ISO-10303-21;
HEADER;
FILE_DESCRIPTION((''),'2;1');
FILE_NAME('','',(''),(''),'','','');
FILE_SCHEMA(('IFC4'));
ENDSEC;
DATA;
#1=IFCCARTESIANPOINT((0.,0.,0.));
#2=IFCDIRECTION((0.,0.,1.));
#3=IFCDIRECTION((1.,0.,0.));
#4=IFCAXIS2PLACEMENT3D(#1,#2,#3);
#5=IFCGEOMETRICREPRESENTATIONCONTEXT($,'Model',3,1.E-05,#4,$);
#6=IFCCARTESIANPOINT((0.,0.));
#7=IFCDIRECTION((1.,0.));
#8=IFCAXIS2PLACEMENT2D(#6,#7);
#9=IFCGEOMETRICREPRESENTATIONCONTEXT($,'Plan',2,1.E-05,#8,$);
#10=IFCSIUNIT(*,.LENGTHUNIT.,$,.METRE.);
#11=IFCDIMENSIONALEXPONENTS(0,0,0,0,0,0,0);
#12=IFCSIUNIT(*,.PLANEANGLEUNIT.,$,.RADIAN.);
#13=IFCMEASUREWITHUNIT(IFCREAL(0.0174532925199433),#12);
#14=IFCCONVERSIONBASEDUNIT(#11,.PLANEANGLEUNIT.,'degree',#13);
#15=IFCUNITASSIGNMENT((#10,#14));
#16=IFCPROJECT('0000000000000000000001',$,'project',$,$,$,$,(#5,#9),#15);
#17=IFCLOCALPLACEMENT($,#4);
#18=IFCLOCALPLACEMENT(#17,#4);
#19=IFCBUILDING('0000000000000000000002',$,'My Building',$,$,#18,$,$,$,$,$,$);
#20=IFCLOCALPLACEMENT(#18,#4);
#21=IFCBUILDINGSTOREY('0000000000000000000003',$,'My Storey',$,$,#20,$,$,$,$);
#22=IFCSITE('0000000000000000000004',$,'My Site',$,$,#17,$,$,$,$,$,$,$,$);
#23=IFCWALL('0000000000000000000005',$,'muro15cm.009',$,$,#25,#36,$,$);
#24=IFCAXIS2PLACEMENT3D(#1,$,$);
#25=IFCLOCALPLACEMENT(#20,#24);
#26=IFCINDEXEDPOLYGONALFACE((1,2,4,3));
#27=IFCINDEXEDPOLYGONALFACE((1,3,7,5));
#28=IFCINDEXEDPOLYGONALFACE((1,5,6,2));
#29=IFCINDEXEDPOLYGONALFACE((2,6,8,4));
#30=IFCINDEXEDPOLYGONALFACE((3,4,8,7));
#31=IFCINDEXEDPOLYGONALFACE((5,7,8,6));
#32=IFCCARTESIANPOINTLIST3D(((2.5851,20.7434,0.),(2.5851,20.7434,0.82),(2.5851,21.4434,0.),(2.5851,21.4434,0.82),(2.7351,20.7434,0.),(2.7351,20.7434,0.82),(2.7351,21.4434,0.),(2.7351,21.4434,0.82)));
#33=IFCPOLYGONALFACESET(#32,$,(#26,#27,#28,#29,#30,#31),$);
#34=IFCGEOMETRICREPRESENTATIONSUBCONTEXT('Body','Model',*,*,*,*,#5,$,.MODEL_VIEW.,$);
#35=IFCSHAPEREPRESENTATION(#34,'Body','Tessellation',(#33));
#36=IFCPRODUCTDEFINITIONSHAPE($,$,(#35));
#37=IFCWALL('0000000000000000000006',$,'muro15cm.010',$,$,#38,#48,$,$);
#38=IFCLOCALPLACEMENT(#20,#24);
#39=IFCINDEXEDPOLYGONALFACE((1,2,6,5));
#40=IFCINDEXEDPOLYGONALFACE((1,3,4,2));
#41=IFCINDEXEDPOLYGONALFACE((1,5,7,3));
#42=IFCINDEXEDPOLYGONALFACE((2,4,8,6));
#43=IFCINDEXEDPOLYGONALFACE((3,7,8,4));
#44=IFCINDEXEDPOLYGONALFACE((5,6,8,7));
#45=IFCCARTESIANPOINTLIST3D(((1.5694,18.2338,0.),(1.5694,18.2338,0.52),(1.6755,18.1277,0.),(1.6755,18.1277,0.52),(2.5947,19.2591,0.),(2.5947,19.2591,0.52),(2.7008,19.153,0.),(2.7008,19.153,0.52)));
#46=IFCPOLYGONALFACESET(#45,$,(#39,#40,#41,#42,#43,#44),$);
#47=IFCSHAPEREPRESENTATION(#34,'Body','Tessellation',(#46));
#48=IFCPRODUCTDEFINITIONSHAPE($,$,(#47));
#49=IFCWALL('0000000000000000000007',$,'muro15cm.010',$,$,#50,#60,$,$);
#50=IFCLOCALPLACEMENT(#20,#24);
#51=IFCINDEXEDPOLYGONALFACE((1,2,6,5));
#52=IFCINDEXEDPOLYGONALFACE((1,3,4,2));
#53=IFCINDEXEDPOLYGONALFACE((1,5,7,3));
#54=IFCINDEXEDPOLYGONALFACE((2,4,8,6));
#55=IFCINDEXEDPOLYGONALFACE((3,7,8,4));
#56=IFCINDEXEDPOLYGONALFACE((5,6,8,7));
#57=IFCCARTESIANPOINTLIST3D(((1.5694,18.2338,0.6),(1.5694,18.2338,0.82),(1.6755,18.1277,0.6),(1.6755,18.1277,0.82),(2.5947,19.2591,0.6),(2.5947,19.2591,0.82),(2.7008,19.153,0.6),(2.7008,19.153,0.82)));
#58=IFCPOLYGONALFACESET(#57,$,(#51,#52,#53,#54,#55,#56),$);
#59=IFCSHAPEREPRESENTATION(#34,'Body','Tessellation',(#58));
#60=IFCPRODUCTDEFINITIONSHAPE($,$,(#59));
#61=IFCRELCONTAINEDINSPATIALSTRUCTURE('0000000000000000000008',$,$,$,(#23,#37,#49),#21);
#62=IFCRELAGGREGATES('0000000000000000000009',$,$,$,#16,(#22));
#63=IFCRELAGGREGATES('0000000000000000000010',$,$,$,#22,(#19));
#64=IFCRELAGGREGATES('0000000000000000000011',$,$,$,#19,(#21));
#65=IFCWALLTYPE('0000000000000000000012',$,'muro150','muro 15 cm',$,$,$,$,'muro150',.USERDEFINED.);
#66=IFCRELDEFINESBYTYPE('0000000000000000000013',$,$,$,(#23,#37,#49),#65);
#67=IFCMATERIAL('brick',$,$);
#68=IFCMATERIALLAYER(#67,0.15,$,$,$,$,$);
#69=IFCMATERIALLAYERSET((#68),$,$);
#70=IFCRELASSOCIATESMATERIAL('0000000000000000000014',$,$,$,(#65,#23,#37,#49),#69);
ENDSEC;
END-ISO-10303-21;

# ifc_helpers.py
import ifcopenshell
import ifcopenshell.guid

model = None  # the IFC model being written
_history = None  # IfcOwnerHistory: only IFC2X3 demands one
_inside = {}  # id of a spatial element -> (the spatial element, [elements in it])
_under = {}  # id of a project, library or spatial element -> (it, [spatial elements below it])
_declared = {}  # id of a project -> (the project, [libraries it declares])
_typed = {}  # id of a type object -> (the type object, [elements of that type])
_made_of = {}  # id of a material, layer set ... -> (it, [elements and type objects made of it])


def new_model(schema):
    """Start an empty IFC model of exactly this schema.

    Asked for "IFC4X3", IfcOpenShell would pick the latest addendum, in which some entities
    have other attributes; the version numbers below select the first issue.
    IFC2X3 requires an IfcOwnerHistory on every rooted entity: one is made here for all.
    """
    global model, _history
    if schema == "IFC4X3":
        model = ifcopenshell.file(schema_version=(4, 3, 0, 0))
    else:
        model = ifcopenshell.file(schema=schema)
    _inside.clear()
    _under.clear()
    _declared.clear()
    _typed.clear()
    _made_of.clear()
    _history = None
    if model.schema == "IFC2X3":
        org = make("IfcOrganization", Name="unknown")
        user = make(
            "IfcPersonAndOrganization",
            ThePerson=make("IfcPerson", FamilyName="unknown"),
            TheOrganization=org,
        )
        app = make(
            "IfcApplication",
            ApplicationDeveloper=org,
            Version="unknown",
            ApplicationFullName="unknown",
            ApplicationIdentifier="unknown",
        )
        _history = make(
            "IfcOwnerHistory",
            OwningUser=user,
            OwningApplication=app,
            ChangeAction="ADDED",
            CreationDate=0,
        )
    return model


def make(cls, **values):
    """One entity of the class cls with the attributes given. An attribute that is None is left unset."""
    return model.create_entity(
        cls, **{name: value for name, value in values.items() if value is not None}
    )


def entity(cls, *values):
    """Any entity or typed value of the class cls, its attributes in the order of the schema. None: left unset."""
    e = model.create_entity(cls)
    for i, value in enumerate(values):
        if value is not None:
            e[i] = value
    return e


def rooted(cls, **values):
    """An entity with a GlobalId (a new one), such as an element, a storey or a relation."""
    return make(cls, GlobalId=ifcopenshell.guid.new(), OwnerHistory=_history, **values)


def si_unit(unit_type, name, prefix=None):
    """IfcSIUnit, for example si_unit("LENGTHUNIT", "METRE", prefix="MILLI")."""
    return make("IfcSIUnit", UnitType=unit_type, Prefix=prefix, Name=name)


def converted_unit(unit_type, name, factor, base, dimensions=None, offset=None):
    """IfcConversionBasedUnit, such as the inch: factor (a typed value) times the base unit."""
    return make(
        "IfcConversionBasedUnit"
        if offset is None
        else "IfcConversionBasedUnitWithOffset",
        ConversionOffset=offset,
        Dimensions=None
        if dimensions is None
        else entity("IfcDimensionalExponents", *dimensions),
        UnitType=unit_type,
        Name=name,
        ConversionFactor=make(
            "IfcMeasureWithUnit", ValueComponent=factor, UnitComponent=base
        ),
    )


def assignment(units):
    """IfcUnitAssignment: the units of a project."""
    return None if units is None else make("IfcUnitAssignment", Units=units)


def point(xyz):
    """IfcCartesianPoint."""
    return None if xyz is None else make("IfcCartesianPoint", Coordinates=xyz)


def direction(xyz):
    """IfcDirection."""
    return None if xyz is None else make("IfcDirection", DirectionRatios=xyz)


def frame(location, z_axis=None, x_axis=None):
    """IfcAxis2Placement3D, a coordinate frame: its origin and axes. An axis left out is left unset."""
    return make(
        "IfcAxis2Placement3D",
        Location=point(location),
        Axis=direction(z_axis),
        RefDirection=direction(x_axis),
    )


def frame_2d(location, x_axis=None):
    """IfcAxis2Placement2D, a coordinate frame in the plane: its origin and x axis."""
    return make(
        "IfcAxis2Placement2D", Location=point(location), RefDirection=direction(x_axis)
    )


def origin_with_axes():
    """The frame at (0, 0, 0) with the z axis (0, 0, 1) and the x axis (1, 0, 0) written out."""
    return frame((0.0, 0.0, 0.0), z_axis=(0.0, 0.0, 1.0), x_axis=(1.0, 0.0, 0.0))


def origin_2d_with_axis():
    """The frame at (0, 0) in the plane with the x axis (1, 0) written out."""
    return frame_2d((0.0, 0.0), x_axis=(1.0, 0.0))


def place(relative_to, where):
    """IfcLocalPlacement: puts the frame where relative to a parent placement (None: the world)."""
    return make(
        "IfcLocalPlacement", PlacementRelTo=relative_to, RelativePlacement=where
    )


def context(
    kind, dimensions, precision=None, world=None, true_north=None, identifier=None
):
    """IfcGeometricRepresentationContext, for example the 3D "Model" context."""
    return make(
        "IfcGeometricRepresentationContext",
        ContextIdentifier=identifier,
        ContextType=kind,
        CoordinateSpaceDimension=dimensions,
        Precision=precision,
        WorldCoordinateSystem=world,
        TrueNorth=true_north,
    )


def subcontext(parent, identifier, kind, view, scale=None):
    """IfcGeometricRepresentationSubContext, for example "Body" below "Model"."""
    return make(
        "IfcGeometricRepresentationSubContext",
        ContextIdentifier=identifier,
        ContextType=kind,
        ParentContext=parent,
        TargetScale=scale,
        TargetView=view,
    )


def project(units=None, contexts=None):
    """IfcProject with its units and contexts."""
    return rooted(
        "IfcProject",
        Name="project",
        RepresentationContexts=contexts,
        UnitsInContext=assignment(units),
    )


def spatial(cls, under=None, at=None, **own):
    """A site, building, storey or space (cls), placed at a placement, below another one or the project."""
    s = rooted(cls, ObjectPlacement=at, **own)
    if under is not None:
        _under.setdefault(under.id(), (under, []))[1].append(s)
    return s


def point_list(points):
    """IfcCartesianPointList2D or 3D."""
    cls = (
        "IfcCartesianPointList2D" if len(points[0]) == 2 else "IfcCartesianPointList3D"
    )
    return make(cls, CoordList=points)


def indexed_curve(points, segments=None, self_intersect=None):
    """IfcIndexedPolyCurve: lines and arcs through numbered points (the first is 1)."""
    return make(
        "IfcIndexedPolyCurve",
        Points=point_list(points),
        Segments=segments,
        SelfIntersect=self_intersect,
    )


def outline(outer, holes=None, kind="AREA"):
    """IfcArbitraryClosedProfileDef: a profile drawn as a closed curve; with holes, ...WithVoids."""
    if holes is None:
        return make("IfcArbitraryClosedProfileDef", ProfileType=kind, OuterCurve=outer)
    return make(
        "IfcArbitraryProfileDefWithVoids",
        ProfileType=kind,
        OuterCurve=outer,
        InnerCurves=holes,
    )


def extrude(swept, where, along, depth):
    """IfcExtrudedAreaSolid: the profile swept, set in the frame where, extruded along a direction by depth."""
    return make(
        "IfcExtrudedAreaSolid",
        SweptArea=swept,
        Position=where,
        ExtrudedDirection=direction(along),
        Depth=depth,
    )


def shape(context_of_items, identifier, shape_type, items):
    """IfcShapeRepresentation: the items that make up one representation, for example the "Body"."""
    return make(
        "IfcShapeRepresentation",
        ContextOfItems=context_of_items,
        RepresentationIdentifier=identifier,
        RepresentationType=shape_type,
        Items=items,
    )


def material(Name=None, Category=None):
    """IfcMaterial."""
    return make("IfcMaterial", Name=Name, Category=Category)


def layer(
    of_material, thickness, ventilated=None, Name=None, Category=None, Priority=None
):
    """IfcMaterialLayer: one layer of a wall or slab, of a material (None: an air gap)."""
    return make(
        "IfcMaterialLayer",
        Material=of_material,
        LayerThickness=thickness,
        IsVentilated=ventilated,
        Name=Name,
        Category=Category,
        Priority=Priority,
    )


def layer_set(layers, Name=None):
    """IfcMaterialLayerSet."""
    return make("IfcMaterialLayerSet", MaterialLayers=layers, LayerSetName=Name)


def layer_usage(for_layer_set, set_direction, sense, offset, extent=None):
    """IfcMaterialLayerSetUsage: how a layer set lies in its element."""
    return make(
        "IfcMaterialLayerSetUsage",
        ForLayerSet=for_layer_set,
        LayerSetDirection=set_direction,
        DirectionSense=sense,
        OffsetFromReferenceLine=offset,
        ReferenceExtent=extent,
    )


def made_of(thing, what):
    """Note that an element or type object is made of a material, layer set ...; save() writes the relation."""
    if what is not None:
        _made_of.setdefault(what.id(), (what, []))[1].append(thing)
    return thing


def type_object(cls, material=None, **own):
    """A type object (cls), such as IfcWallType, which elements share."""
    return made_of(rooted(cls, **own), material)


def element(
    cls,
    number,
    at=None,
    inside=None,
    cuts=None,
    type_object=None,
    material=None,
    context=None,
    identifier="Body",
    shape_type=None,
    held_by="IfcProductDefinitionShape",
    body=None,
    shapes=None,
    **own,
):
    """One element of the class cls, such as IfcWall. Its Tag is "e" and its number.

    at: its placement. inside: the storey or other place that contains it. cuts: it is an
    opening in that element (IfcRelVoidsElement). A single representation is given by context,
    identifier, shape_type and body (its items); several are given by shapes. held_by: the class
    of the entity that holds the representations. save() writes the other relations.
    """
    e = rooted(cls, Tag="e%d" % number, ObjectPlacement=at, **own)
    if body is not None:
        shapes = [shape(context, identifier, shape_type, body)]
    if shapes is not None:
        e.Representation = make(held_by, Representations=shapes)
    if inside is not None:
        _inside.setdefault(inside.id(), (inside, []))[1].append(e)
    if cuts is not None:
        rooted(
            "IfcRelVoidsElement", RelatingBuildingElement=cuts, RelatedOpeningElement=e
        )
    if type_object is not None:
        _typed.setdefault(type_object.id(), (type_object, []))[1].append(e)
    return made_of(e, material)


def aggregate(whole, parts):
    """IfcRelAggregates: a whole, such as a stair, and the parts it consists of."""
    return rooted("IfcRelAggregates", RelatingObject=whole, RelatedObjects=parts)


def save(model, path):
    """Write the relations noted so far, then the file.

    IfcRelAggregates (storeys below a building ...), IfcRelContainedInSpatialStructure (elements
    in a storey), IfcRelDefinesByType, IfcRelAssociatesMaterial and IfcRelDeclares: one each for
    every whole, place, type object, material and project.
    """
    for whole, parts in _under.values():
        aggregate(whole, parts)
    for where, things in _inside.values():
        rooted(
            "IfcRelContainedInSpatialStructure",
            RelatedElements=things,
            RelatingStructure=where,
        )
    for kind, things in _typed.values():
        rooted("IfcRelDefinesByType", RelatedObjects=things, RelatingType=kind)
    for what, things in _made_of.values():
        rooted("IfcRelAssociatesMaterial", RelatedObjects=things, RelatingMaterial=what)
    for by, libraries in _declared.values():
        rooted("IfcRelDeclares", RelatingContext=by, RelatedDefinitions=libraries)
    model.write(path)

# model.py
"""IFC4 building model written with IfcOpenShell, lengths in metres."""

from ifc_helpers import new_model, entity, si_unit, converted_unit, frame, origin_with_axes, origin_2d_with_axis, place, context, subcontext, project, spatial, indexed_curve, outline, extrude, material, layer, layer_set, layer_usage, type_object, element, save


model = new_model("IFC4")

# Units and contexts
model_context = context("Model", 3, precision=1e-05, world=origin_with_axes())
plan_context = context("Plan", 2, precision=1e-05, world=origin_2d_with_axis())
body_context = subcontext(model_context, "Body", "Model", "MODEL_VIEW")
ifc_project = project(units=[si_unit("LENGTHUNIT", "METRE"), converted_unit("PLANEANGLEUNIT", "degree", entity("IfcReal", 0.0174532925199433), si_unit("PLANEANGLEUNIT", "RADIAN"), dimensions=[0, 0, 0, 0, 0, 0, 0])], contexts=[model_context, plan_context])

# Site, building, storey
site_placement = place(None, origin_with_axes())
site = spatial("IfcSite", under=ifc_project, at=site_placement, Name="My Site")
building_placement = place(site_placement, origin_with_axes())
building = spatial("IfcBuilding", under=site, at=building_placement, Name="My Building")
storey_placement = place(building_placement, origin_with_axes())
storey = spatial("IfcBuildingStorey", under=building, at=storey_placement, Name="My Storey")

# Walls
ifc_material_1 = material(Name="brick")
ifc_layer_1 = layer(ifc_material_1, 0.15)
ifc_layer_set_1 = layer_set([ifc_layer_1])
ifc_layer_usage_1 = layer_usage(ifc_layer_set_1, "AXIS2", "POSITIVE", 0.0)
wall_type_1 = type_object("IfcWallType", Name="muro150", Description="muro 15 cm", ElementType="muro150", PredefinedType="USERDEFINED", material=ifc_layer_set_1)
wall_1_placement = place(storey_placement, frame((2.7351, 20.7434, 0.0), z_axis=(0.0, 0.0, 1.0), x_axis=(0.0, 1.0, 0.0)))
element("IfcWall", 1, at=wall_1_placement, inside=storey, type_object=wall_type_1, material=ifc_layer_usage_1, Name="muro15cm.009", context=body_context, shape_type="SweptSolid", body=[
    extrude(outline(indexed_curve([(0.0, 0.0), (0.0, 0.15), (0.7, 0.15), (0.7, 0.0), (0.0, 0.0)], self_intersect=False)), origin_with_axes(), (0.0, 0.0, 1.0), 0.82),
])
ifc_layer_usage_2 = layer_usage(ifc_layer_set_1, "AXIS2", "POSITIVE", 0.0)
wall_2_placement = place(storey_placement, frame((2.5947, 19.2591, 0.0), z_axis=(0.0, 0.0, 1.0), x_axis=(-0.707107, -0.707107, 0.0)))
element("IfcWall", 2, at=wall_2_placement, inside=storey, type_object=wall_type_1, material=ifc_layer_usage_2, Name="muro15cm.010", context=body_context, shape_type="SweptSolid", body=[
    extrude(outline(indexed_curve([(0.0, 0.0), (0.0, 0.15), (1.45, 0.15), (1.45, 0.0), (0.0, 0.0)], self_intersect=False)), origin_with_axes(), (0.0, 0.0, 1.0), 0.52),
])
ifc_layer_usage_3 = layer_usage(ifc_layer_set_1, "AXIS2", "POSITIVE", 0.0)
wall_3_placement = place(storey_placement, frame((2.5947, 19.2591, 0.6), z_axis=(0.0, 0.0, 1.0), x_axis=(-0.707107, -0.707107, 0.0)))
element("IfcWall", 3, at=wall_3_placement, inside=storey, type_object=wall_type_1, material=ifc_layer_usage_3, Name="muro15cm.010", context=body_context, shape_type="SweptSolid", body=[
    extrude(outline(indexed_curve([(0.0, 0.0), (0.0, 0.15), (1.45, 0.15), (1.45, 0.0), (0.0, 0.0)], self_intersect=False)), origin_with_axes(), (0.0, 0.0, 1.0), 0.22),
])

save(model, "model.ifc")
